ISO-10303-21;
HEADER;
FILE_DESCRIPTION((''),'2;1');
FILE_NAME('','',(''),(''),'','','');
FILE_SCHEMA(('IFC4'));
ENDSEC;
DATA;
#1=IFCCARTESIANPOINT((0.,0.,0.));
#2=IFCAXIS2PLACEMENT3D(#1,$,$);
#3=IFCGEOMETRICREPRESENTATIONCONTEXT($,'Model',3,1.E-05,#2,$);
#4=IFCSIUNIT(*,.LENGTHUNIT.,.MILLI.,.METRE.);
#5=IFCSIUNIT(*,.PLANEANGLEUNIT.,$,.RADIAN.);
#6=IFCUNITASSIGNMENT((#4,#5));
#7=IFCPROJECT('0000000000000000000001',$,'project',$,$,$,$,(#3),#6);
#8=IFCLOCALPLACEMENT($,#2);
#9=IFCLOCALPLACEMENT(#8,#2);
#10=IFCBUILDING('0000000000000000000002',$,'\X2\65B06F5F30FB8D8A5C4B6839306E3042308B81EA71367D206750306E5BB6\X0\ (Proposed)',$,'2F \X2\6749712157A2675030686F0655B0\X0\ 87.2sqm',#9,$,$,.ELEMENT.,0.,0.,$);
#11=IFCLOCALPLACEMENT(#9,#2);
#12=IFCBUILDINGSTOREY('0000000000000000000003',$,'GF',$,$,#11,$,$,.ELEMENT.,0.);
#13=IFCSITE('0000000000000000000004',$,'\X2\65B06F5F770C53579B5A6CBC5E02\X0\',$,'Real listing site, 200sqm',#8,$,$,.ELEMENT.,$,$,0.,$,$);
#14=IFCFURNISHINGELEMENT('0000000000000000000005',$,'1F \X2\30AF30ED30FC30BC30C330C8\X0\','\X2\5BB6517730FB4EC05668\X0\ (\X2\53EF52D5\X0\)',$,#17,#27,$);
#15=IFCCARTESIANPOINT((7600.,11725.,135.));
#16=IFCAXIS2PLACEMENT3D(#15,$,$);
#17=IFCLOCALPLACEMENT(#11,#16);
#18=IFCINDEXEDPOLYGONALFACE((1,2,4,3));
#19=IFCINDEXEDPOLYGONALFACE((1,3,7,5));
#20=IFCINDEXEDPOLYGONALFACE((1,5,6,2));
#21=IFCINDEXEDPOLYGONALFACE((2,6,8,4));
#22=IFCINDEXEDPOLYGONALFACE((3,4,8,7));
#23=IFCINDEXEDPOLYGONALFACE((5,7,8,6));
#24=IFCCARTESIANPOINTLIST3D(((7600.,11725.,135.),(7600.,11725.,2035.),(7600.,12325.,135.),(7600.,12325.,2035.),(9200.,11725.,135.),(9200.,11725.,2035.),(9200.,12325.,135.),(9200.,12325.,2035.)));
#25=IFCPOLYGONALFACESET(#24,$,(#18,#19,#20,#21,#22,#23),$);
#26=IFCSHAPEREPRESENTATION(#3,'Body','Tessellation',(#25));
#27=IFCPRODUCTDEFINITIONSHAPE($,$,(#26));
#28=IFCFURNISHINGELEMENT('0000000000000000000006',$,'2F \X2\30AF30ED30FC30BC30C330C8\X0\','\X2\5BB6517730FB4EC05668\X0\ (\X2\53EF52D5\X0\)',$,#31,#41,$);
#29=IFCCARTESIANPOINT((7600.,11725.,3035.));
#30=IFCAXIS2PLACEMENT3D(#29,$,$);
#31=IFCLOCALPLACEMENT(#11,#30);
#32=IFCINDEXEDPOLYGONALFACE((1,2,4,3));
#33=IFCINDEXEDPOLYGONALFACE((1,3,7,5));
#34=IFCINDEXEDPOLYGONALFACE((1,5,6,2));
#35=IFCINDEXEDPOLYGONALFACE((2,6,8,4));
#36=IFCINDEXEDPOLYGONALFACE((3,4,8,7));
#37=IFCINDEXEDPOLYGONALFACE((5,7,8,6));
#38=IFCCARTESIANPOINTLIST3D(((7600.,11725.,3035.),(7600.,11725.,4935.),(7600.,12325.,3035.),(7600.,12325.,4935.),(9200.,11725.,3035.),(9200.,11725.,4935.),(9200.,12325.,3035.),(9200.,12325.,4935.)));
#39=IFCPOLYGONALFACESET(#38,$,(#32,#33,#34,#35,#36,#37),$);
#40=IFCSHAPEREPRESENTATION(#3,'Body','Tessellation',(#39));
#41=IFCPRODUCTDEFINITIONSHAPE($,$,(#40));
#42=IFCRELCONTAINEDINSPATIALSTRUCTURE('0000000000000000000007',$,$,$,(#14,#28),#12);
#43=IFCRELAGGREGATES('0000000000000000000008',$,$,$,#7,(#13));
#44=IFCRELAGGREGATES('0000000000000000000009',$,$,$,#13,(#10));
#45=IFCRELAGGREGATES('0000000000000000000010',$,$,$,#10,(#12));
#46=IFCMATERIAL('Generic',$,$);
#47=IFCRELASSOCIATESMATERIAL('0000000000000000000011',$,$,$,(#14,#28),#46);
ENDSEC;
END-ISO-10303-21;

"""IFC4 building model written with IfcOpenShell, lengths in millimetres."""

from ifc_helpers import new_model, si_unit, frame, frame_2d, origin, place, context, project, spatial, rectangle, extrude, material, element, save


model = new_model("IFC4")

# Units and contexts
model_context = context("Model", 3, precision=1e-05, world=origin())
ifc_project = project(units=[si_unit("LENGTHUNIT", "METRE", prefix="MILLI"), si_unit("PLANEANGLEUNIT", "RADIAN")], contexts=[model_context])

# Site, building, storey
site_placement = place(None, origin())
site = spatial("IfcSite", under=ifc_project, at=site_placement, Name="新潟県南魚沼市", ObjectType="Real listing site, 200sqm", CompositionType="ELEMENT", RefElevation=0.0)
building_placement = place(site_placement, origin())
building = spatial("IfcBuilding", under=site, at=building_placement, Name="新潟・越屋根のある自然素材の家 (Proposed)", ObjectType="2F 杉無垢材と漆喰 87.2sqm", CompositionType="ELEMENT", ElevationOfRefHeight=0.0, ElevationOfTerrain=0.0)
storey_placement = place(building_placement, origin())
storey = spatial("IfcBuildingStorey", under=building, at=storey_placement, Name="GF", CompositionType="ELEMENT", Elevation=0.0)

# Shared definitions
ifc_material_1 = material(Name="Generic")

# Furnishing elements
furnishing_1_placement = place(storey_placement, frame((7600.0, 11725.0, 135.0)))
element("IfcFurnishingElement", 1, at=furnishing_1_placement, inside=storey, material=ifc_material_1, Name="1F クローゼット", Description="家具・什器 (可動)", context=model_context, shape_type="SweptSolid", body=[
    extrude(rectangle(XDim=1600.0, YDim=600.0, at=frame_2d((800.0, 300.0))), frame((7600.0, 11725.0, 135.0)), (0.0, 0.0, 1.0), 1900.0),
])
furnishing_2_placement = place(storey_placement, frame((7600.0, 11725.0, 3035.0)))
element("IfcFurnishingElement", 2, at=furnishing_2_placement, inside=storey, material=ifc_material_1, Name="2F クローゼット", Description="家具・什器 (可動)", context=model_context, shape_type="SweptSolid", body=[
    extrude(rectangle(XDim=1600.0, YDim=600.0, at=frame_2d((800.0, 300.0))), frame((7600.0, 11725.0, 3035.0)), (0.0, 0.0, 1.0), 1900.0),
])

save(model, "model.ifc")
